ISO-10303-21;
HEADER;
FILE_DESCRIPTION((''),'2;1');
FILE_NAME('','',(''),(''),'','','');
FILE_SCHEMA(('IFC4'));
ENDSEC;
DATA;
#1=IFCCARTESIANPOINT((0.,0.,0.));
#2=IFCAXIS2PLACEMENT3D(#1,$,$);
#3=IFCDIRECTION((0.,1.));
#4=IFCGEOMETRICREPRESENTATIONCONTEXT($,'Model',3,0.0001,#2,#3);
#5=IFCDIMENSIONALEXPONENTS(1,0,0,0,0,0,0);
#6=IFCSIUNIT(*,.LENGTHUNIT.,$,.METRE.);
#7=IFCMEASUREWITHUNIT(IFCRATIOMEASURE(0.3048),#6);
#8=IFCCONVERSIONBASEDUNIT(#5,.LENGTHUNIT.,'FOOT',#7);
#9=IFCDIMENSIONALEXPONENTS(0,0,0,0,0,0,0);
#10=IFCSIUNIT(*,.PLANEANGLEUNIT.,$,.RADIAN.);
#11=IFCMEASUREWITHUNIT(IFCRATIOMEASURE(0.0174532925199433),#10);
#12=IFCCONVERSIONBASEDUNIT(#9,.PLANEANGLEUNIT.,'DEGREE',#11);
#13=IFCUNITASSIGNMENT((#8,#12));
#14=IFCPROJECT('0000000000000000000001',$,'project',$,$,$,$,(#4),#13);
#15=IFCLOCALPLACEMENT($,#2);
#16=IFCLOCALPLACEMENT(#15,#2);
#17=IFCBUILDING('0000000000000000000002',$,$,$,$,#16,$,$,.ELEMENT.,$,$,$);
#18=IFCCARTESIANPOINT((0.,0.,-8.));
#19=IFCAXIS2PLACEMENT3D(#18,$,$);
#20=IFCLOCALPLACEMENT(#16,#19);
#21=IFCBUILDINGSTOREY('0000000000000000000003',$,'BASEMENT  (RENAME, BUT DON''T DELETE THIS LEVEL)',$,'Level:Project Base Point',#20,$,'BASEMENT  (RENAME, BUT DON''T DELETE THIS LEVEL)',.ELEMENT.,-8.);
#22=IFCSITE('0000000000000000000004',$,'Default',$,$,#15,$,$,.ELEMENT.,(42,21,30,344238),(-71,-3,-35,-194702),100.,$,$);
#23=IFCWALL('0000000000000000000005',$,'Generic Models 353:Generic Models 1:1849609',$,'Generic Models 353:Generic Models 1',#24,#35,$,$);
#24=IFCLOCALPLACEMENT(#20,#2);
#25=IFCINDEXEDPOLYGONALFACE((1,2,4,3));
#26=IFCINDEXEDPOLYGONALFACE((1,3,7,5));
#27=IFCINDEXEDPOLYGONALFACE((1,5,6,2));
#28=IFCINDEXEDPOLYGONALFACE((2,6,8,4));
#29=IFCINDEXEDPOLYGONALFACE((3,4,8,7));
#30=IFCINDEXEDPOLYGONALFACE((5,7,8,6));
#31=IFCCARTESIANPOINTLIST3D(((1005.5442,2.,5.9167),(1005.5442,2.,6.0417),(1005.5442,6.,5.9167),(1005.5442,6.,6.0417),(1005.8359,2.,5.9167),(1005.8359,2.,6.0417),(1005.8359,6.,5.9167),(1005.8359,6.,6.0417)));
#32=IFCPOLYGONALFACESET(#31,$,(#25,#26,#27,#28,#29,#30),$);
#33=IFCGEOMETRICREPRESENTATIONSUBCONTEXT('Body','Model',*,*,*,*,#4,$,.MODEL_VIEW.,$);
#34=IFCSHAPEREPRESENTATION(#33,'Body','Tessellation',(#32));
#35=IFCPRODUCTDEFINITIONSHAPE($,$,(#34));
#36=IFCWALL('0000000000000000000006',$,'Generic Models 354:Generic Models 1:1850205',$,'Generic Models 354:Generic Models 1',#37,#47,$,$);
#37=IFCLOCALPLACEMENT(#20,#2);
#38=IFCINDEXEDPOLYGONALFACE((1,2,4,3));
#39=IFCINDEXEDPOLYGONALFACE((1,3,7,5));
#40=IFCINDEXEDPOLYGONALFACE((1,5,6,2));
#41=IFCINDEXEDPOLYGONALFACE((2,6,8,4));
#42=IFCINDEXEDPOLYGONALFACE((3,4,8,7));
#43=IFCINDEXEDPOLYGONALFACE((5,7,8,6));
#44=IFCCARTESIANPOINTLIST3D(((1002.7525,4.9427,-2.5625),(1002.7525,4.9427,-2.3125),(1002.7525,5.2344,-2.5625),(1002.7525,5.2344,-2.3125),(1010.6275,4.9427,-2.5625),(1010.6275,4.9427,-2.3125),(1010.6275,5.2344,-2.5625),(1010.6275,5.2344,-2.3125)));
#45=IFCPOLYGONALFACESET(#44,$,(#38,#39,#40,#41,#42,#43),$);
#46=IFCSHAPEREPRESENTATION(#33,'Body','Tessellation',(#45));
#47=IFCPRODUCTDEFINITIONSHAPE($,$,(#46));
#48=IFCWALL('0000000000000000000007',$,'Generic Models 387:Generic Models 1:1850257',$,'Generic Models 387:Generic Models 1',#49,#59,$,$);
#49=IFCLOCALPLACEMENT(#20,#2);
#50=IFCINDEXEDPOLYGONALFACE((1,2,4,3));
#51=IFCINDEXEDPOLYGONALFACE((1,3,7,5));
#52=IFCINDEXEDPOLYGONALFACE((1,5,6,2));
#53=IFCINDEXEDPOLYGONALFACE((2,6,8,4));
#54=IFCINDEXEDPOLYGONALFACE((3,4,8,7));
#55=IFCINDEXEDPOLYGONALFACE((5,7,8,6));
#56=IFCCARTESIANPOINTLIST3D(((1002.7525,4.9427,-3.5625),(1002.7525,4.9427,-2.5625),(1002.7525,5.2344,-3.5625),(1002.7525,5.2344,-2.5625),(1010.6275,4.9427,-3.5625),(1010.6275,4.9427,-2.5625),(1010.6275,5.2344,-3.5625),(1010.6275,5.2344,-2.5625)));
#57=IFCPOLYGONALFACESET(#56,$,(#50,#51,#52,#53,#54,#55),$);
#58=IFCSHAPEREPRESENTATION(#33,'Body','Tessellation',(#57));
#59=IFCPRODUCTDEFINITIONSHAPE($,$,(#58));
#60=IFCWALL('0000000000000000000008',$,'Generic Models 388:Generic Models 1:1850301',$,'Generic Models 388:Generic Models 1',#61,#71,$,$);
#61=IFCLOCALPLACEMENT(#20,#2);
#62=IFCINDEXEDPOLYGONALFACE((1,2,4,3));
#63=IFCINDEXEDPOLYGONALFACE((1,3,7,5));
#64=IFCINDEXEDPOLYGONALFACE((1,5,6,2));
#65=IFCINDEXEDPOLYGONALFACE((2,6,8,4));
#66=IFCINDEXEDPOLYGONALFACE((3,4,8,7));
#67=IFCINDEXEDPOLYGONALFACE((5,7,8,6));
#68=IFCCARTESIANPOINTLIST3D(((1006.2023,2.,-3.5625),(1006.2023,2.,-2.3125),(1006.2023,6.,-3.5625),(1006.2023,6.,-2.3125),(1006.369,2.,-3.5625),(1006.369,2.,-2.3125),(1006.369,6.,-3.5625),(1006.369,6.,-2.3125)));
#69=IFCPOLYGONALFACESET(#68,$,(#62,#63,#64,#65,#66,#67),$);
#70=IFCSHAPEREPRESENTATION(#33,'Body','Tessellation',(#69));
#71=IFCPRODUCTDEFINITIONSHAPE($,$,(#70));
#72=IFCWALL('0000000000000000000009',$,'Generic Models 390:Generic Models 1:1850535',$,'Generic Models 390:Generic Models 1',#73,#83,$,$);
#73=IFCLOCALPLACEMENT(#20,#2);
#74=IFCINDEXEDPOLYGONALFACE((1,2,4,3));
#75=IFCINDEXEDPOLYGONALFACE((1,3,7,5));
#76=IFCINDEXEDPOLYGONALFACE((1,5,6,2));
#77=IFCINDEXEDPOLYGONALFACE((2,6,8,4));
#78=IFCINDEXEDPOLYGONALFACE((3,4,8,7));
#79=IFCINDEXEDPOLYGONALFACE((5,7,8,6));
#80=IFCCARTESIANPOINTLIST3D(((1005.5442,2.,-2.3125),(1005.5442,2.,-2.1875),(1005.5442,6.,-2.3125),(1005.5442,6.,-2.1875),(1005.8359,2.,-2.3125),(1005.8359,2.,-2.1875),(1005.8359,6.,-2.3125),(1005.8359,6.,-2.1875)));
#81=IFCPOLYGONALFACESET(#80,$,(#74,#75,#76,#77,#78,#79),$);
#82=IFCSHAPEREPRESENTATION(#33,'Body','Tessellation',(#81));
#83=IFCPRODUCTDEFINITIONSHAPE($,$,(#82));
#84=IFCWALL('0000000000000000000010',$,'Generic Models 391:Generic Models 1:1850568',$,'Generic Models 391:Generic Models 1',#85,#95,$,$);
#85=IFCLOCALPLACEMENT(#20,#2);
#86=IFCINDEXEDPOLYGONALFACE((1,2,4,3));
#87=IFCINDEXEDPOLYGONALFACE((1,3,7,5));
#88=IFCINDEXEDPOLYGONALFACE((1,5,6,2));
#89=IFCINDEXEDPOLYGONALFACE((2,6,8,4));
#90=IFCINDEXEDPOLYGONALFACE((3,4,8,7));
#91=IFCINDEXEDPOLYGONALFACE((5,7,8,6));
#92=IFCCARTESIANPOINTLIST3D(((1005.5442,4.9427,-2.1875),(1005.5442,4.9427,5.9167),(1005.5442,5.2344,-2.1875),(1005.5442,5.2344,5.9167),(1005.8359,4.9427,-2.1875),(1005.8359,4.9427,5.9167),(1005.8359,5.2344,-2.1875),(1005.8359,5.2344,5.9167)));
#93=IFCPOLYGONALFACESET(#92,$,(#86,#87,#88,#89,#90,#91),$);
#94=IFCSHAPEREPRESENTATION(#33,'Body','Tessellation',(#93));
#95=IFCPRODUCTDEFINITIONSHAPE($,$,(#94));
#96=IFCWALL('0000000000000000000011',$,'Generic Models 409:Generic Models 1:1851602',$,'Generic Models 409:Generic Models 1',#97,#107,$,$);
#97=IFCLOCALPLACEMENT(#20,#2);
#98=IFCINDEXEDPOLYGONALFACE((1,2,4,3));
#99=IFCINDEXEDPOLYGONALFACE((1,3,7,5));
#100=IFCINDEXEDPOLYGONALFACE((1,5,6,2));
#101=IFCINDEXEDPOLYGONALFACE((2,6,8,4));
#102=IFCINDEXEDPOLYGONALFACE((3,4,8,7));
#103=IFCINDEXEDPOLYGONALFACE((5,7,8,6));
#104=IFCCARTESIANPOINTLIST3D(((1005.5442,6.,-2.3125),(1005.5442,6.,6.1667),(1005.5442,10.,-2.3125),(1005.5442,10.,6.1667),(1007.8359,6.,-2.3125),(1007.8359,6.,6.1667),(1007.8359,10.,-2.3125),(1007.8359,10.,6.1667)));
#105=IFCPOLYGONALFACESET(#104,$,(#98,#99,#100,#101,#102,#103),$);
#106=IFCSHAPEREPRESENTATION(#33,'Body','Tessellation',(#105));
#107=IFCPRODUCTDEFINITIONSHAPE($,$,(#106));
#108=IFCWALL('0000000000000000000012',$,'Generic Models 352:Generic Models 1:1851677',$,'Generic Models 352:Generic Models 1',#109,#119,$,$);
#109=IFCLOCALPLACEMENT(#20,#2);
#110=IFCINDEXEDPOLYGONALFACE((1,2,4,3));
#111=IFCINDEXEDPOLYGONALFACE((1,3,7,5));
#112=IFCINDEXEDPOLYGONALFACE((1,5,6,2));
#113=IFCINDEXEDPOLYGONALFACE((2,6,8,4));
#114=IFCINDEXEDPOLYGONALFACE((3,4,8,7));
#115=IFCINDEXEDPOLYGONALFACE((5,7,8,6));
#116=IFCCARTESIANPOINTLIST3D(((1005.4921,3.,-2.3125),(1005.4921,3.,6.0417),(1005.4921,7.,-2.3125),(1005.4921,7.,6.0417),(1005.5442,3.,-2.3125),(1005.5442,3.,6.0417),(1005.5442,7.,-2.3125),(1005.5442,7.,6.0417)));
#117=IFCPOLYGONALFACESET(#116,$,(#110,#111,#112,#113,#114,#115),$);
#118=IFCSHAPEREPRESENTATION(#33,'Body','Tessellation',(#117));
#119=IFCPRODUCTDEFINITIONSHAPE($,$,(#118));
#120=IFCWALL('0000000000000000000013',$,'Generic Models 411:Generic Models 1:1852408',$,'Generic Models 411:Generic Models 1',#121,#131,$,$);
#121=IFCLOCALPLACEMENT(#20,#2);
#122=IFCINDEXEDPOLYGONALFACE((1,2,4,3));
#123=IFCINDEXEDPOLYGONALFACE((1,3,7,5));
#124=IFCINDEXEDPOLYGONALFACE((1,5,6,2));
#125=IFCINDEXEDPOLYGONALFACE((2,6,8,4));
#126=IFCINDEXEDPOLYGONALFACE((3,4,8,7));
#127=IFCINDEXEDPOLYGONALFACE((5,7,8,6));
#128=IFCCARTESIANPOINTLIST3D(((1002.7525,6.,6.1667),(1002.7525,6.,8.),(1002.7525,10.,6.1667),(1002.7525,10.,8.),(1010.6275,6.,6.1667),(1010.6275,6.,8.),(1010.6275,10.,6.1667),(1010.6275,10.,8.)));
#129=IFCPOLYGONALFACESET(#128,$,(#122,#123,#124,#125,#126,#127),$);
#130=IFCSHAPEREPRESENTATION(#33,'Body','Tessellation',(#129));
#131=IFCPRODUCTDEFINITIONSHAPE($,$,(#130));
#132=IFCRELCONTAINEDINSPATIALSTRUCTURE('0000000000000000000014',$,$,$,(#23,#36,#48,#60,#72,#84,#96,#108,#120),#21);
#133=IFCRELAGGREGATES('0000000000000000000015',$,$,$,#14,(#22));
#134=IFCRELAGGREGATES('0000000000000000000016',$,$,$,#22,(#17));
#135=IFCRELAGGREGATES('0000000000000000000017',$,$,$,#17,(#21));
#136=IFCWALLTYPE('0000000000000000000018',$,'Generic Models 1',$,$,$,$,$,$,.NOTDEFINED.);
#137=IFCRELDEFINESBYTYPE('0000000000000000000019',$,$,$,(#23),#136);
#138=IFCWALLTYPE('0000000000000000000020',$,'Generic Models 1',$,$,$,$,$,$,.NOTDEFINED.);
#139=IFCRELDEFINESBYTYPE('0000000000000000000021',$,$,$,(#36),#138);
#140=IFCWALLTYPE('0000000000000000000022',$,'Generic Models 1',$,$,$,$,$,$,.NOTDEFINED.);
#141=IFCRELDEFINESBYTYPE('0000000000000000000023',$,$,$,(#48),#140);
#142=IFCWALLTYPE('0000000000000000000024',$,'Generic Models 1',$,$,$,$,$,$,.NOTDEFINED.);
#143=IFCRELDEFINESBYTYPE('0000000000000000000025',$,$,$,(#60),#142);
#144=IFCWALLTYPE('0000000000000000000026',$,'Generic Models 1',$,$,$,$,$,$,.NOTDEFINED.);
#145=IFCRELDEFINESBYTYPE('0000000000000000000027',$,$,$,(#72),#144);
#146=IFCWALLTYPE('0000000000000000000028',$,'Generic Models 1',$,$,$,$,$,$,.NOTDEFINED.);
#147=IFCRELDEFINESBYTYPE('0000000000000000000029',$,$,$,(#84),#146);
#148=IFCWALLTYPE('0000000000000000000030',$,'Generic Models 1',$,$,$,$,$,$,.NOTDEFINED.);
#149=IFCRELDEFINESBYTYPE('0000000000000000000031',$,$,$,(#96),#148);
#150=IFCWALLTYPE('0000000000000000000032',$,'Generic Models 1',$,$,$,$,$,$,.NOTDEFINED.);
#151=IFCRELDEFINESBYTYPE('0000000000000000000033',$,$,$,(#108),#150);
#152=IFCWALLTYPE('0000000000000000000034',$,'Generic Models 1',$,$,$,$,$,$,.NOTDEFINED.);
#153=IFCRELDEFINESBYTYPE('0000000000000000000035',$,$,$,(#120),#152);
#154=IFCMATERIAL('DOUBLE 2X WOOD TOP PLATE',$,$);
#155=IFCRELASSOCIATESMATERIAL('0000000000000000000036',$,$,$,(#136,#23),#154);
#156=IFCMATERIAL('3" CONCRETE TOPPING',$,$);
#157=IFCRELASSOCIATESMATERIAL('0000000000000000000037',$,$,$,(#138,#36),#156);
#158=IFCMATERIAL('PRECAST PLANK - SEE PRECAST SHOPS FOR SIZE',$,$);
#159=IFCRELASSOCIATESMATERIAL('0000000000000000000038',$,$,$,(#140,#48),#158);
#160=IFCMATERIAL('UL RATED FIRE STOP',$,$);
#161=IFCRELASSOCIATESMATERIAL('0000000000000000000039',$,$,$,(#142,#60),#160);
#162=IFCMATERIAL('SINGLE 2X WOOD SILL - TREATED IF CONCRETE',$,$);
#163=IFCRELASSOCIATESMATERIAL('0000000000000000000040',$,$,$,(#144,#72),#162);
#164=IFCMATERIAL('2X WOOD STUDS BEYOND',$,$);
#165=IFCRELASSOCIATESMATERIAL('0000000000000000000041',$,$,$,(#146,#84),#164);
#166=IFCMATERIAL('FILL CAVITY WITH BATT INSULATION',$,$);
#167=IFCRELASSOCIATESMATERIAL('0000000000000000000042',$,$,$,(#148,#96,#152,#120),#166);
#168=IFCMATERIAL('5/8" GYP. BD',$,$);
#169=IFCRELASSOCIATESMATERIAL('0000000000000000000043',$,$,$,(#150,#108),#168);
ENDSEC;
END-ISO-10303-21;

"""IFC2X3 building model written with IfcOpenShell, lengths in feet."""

from ifc_helpers import new_model, entity, si_unit, converted_unit, direction, frame, frame_2d, origin, origin_2d_with_axis, place, context, subcontext, project, spatial, rectangle, extrude, material, type_object, element, save


model = new_model("IFC2X3")

# Units and contexts
model_context = context("Model", 3, precision=0.0001, world=origin(), true_north=direction((0.0, 1.0)))
body_context = subcontext(model_context, "Body", "Model", "MODEL_VIEW")
ifc_project = project(units=[converted_unit("LENGTHUNIT", "FOOT", entity("IfcRatioMeasure", 0.3048), si_unit("LENGTHUNIT", "METRE"), dimensions=[1, 0, 0, 0, 0, 0, 0]), converted_unit("PLANEANGLEUNIT", "DEGREE", entity("IfcRatioMeasure", 0.0174532925199433), si_unit("PLANEANGLEUNIT", "RADIAN"), dimensions=[0, 0, 0, 0, 0, 0, 0])], contexts=[model_context])

# Site, building, storey
site_placement = place(None, origin())
site = spatial("IfcSite", under=ifc_project, at=site_placement, Name="Default", CompositionType="ELEMENT", RefLatitude=(42, 21, 30, 344238), RefLongitude=(-71, -3, -35, -194702), RefElevation=100.0)
building_placement = place(site_placement, origin())
building = spatial("IfcBuilding", under=site, at=building_placement, CompositionType="ELEMENT")
storey_placement = place(building_placement, frame((0.0, 0.0, -8.0)))
storey = spatial("IfcBuildingStorey", under=building, at=storey_placement, Name="BASEMENT  (RENAME, BUT DON'T DELETE THIS LEVEL)", ObjectType="Level:Project Base Point", LongName="BASEMENT  (RENAME, BUT DON'T DELETE THIS LEVEL)", CompositionType="ELEMENT", Elevation=-8.0)

# Walls
ifc_material_1 = material(Name="FILL CAVITY WITH BATT INSULATION")
ifc_material_2 = material(Name="DOUBLE 2X WOOD TOP PLATE")
wall_type_1 = type_object("IfcWallType", Name="Generic Models 1", PredefinedType="NOTDEFINED", material=ifc_material_2)
wall_1_placement = place(storey_placement, frame((1005.5442, 2.0, 5.9167), z_axis=(0.0, 0.0, 1.0), x_axis=(0.0, 1.0, 0.0)))
element("IfcWall", 1, at=wall_1_placement, inside=storey, type_object=wall_type_1, material=ifc_material_2, Name="Generic Models 353:Generic Models 1:1849609", ObjectType="Generic Models 353:Generic Models 1", context=body_context, shape_type="SweptSolid", body=[
    extrude(rectangle(XDim=4.0, YDim=0.2917, at=frame_2d((0.0, 0.0), x_axis=(1.0, 0.0))), frame((2.0, -0.1458, 0.0)), (0.0, 0.0, 1.0), 0.125),
])
ifc_material_3 = material(Name="3\" CONCRETE TOPPING")
wall_type_2 = type_object("IfcWallType", Name="Generic Models 1", PredefinedType="NOTDEFINED", material=ifc_material_3)
wall_2_placement = place(storey_placement, frame((1002.7525, 4.9427, -2.5625)))
element("IfcWall", 2, at=wall_2_placement, inside=storey, type_object=wall_type_2, material=ifc_material_3, Name="Generic Models 354:Generic Models 1:1850205", ObjectType="Generic Models 354:Generic Models 1", context=body_context, shape_type="SweptSolid", body=[
    extrude(rectangle(XDim=0.2917, YDim=7.875, at=origin_2d_with_axis()), frame((3.9375, 0.1458, 0.0), z_axis=(0.0, 0.0, 1.0), x_axis=(0.0, 1.0, 0.0)), (0.0, 0.0, 1.0), 0.25),
])
ifc_material_4 = material(Name="PRECAST PLANK - SEE PRECAST SHOPS FOR SIZE")
wall_type_3 = type_object("IfcWallType", Name="Generic Models 1", PredefinedType="NOTDEFINED", material=ifc_material_4)
wall_3_placement = place(storey_placement, frame((1002.7525, 4.9427, -3.5625)))
element("IfcWall", 3, at=wall_3_placement, inside=storey, type_object=wall_type_3, material=ifc_material_4, Name="Generic Models 387:Generic Models 1:1850257", ObjectType="Generic Models 387:Generic Models 1", context=body_context, shape_type="SweptSolid", body=[
    extrude(rectangle(XDim=0.2917, YDim=7.875, at=origin_2d_with_axis()), frame((3.9375, 0.1458, 0.0), z_axis=(0.0, 0.0, 1.0), x_axis=(0.0, 1.0, 0.0)), (0.0, 0.0, 1.0), 1.0),
])
ifc_material_5 = material(Name="UL RATED FIRE STOP")
wall_type_4 = type_object("IfcWallType", Name="Generic Models 1", PredefinedType="NOTDEFINED", material=ifc_material_5)
wall_4_placement = place(storey_placement, frame((1006.2023, 2.0, -3.5625), z_axis=(0.0, 0.0, 1.0), x_axis=(0.0, 1.0, 0.0)))
element("IfcWall", 4, at=wall_4_placement, inside=storey, type_object=wall_type_4, material=ifc_material_5, Name="Generic Models 388:Generic Models 1:1850301", ObjectType="Generic Models 388:Generic Models 1", context=body_context, shape_type="SweptSolid", body=[
    extrude(rectangle(XDim=4.0, YDim=0.1667, at=frame_2d((0.0, 0.0), x_axis=(1.0, 0.0))), frame((2.0, -0.0833, 0.0)), (0.0, 0.0, 1.0), 1.25),
])
ifc_material_6 = material(Name="SINGLE 2X WOOD SILL - TREATED IF CONCRETE")
wall_type_5 = type_object("IfcWallType", Name="Generic Models 1", PredefinedType="NOTDEFINED", material=ifc_material_6)
wall_5_placement = place(storey_placement, frame((1005.5442, 2.0, -2.3125), z_axis=(0.0, 0.0, 1.0), x_axis=(0.0, 1.0, 0.0)))
element("IfcWall", 5, at=wall_5_placement, inside=storey, type_object=wall_type_5, material=ifc_material_6, Name="Generic Models 390:Generic Models 1:1850535", ObjectType="Generic Models 390:Generic Models 1", context=body_context, shape_type="SweptSolid", body=[
    extrude(rectangle(XDim=4.0, YDim=0.2917, at=frame_2d((0.0, 0.0), x_axis=(1.0, 0.0))), frame((2.0, -0.1458, 0.0)), (0.0, 0.0, 1.0), 0.125),
])
ifc_material_7 = material(Name="2X WOOD STUDS BEYOND")
wall_type_6 = type_object("IfcWallType", Name="Generic Models 1", PredefinedType="NOTDEFINED", material=ifc_material_7)
wall_6_placement = place(storey_placement, frame((1005.5442, 4.9427, -2.1875)))
element("IfcWall", 6, at=wall_6_placement, inside=storey, type_object=wall_type_6, material=ifc_material_7, Name="Generic Models 391:Generic Models 1:1850568", ObjectType="Generic Models 391:Generic Models 1", context=body_context, shape_type="SweptSolid", body=[
    extrude(rectangle(XDim=0.2917, YDim=0.2917, at=origin_2d_with_axis()), frame((0.1458, 0.1458, 0.0), z_axis=(0.0, 0.0, 1.0), x_axis=(0.0, 1.0, 0.0)), (0.0, 0.0, 1.0), 8.1042),
])
wall_type_7 = type_object("IfcWallType", Name="Generic Models 1", PredefinedType="NOTDEFINED", material=ifc_material_1)
wall_7_placement = place(storey_placement, frame((1005.5442, 6.0, -2.3125), z_axis=(0.0, 0.0, 1.0), x_axis=(0.0, 1.0, 0.0)))
element("IfcWall", 7, at=wall_7_placement, inside=storey, type_object=wall_type_7, material=ifc_material_1, Name="Generic Models 409:Generic Models 1:1851602", ObjectType="Generic Models 409:Generic Models 1", context=body_context, shape_type="SweptSolid", body=[
    extrude(rectangle(XDim=4.0, YDim=2.2917, at=frame_2d((0.0, 0.0), x_axis=(1.0, 0.0))), frame((2.0, -1.1458, 0.0)), (0.0, 0.0, 1.0), 8.4792),
])
ifc_material_8 = material(Name="5/8\" GYP. BD")
wall_type_8 = type_object("IfcWallType", Name="Generic Models 1", PredefinedType="NOTDEFINED", material=ifc_material_8)
wall_8_placement = place(storey_placement, frame((1005.4921, 3.0, -2.3125), z_axis=(0.0, 0.0, 1.0), x_axis=(0.0, 1.0, 0.0)))
element("IfcWall", 8, at=wall_8_placement, inside=storey, type_object=wall_type_8, material=ifc_material_8, Name="Generic Models 352:Generic Models 1:1851677", ObjectType="Generic Models 352:Generic Models 1", context=body_context, shape_type="SweptSolid", body=[
    extrude(rectangle(XDim=4.0, YDim=0.0521, at=frame_2d((0.0, 0.0), x_axis=(1.0, 0.0))), frame((2.0, -0.026, 0.0)), (0.0, 0.0, 1.0), 8.3542),
])
wall_type_9 = type_object("IfcWallType", Name="Generic Models 1", PredefinedType="NOTDEFINED", material=ifc_material_1)
wall_9_placement = place(storey_placement, frame((1002.7525, 6.0, 6.1667)))
element("IfcWall", 9, at=wall_9_placement, inside=storey, type_object=wall_type_9, material=ifc_material_1, Name="Generic Models 411:Generic Models 1:1852408", ObjectType="Generic Models 411:Generic Models 1", context=body_context, shape_type="SweptSolid", body=[
    extrude(rectangle(XDim=4.0, YDim=7.875, at=frame_2d((0.0, 0.0), x_axis=(1.0, 0.0))), frame((3.9375, 2.0, 0.0), z_axis=(0.0, 0.0, 1.0), x_axis=(0.0, 1.0, 0.0)), (0.0, 0.0, 1.0), 1.8333),
])

save(model, "model.ifc")
